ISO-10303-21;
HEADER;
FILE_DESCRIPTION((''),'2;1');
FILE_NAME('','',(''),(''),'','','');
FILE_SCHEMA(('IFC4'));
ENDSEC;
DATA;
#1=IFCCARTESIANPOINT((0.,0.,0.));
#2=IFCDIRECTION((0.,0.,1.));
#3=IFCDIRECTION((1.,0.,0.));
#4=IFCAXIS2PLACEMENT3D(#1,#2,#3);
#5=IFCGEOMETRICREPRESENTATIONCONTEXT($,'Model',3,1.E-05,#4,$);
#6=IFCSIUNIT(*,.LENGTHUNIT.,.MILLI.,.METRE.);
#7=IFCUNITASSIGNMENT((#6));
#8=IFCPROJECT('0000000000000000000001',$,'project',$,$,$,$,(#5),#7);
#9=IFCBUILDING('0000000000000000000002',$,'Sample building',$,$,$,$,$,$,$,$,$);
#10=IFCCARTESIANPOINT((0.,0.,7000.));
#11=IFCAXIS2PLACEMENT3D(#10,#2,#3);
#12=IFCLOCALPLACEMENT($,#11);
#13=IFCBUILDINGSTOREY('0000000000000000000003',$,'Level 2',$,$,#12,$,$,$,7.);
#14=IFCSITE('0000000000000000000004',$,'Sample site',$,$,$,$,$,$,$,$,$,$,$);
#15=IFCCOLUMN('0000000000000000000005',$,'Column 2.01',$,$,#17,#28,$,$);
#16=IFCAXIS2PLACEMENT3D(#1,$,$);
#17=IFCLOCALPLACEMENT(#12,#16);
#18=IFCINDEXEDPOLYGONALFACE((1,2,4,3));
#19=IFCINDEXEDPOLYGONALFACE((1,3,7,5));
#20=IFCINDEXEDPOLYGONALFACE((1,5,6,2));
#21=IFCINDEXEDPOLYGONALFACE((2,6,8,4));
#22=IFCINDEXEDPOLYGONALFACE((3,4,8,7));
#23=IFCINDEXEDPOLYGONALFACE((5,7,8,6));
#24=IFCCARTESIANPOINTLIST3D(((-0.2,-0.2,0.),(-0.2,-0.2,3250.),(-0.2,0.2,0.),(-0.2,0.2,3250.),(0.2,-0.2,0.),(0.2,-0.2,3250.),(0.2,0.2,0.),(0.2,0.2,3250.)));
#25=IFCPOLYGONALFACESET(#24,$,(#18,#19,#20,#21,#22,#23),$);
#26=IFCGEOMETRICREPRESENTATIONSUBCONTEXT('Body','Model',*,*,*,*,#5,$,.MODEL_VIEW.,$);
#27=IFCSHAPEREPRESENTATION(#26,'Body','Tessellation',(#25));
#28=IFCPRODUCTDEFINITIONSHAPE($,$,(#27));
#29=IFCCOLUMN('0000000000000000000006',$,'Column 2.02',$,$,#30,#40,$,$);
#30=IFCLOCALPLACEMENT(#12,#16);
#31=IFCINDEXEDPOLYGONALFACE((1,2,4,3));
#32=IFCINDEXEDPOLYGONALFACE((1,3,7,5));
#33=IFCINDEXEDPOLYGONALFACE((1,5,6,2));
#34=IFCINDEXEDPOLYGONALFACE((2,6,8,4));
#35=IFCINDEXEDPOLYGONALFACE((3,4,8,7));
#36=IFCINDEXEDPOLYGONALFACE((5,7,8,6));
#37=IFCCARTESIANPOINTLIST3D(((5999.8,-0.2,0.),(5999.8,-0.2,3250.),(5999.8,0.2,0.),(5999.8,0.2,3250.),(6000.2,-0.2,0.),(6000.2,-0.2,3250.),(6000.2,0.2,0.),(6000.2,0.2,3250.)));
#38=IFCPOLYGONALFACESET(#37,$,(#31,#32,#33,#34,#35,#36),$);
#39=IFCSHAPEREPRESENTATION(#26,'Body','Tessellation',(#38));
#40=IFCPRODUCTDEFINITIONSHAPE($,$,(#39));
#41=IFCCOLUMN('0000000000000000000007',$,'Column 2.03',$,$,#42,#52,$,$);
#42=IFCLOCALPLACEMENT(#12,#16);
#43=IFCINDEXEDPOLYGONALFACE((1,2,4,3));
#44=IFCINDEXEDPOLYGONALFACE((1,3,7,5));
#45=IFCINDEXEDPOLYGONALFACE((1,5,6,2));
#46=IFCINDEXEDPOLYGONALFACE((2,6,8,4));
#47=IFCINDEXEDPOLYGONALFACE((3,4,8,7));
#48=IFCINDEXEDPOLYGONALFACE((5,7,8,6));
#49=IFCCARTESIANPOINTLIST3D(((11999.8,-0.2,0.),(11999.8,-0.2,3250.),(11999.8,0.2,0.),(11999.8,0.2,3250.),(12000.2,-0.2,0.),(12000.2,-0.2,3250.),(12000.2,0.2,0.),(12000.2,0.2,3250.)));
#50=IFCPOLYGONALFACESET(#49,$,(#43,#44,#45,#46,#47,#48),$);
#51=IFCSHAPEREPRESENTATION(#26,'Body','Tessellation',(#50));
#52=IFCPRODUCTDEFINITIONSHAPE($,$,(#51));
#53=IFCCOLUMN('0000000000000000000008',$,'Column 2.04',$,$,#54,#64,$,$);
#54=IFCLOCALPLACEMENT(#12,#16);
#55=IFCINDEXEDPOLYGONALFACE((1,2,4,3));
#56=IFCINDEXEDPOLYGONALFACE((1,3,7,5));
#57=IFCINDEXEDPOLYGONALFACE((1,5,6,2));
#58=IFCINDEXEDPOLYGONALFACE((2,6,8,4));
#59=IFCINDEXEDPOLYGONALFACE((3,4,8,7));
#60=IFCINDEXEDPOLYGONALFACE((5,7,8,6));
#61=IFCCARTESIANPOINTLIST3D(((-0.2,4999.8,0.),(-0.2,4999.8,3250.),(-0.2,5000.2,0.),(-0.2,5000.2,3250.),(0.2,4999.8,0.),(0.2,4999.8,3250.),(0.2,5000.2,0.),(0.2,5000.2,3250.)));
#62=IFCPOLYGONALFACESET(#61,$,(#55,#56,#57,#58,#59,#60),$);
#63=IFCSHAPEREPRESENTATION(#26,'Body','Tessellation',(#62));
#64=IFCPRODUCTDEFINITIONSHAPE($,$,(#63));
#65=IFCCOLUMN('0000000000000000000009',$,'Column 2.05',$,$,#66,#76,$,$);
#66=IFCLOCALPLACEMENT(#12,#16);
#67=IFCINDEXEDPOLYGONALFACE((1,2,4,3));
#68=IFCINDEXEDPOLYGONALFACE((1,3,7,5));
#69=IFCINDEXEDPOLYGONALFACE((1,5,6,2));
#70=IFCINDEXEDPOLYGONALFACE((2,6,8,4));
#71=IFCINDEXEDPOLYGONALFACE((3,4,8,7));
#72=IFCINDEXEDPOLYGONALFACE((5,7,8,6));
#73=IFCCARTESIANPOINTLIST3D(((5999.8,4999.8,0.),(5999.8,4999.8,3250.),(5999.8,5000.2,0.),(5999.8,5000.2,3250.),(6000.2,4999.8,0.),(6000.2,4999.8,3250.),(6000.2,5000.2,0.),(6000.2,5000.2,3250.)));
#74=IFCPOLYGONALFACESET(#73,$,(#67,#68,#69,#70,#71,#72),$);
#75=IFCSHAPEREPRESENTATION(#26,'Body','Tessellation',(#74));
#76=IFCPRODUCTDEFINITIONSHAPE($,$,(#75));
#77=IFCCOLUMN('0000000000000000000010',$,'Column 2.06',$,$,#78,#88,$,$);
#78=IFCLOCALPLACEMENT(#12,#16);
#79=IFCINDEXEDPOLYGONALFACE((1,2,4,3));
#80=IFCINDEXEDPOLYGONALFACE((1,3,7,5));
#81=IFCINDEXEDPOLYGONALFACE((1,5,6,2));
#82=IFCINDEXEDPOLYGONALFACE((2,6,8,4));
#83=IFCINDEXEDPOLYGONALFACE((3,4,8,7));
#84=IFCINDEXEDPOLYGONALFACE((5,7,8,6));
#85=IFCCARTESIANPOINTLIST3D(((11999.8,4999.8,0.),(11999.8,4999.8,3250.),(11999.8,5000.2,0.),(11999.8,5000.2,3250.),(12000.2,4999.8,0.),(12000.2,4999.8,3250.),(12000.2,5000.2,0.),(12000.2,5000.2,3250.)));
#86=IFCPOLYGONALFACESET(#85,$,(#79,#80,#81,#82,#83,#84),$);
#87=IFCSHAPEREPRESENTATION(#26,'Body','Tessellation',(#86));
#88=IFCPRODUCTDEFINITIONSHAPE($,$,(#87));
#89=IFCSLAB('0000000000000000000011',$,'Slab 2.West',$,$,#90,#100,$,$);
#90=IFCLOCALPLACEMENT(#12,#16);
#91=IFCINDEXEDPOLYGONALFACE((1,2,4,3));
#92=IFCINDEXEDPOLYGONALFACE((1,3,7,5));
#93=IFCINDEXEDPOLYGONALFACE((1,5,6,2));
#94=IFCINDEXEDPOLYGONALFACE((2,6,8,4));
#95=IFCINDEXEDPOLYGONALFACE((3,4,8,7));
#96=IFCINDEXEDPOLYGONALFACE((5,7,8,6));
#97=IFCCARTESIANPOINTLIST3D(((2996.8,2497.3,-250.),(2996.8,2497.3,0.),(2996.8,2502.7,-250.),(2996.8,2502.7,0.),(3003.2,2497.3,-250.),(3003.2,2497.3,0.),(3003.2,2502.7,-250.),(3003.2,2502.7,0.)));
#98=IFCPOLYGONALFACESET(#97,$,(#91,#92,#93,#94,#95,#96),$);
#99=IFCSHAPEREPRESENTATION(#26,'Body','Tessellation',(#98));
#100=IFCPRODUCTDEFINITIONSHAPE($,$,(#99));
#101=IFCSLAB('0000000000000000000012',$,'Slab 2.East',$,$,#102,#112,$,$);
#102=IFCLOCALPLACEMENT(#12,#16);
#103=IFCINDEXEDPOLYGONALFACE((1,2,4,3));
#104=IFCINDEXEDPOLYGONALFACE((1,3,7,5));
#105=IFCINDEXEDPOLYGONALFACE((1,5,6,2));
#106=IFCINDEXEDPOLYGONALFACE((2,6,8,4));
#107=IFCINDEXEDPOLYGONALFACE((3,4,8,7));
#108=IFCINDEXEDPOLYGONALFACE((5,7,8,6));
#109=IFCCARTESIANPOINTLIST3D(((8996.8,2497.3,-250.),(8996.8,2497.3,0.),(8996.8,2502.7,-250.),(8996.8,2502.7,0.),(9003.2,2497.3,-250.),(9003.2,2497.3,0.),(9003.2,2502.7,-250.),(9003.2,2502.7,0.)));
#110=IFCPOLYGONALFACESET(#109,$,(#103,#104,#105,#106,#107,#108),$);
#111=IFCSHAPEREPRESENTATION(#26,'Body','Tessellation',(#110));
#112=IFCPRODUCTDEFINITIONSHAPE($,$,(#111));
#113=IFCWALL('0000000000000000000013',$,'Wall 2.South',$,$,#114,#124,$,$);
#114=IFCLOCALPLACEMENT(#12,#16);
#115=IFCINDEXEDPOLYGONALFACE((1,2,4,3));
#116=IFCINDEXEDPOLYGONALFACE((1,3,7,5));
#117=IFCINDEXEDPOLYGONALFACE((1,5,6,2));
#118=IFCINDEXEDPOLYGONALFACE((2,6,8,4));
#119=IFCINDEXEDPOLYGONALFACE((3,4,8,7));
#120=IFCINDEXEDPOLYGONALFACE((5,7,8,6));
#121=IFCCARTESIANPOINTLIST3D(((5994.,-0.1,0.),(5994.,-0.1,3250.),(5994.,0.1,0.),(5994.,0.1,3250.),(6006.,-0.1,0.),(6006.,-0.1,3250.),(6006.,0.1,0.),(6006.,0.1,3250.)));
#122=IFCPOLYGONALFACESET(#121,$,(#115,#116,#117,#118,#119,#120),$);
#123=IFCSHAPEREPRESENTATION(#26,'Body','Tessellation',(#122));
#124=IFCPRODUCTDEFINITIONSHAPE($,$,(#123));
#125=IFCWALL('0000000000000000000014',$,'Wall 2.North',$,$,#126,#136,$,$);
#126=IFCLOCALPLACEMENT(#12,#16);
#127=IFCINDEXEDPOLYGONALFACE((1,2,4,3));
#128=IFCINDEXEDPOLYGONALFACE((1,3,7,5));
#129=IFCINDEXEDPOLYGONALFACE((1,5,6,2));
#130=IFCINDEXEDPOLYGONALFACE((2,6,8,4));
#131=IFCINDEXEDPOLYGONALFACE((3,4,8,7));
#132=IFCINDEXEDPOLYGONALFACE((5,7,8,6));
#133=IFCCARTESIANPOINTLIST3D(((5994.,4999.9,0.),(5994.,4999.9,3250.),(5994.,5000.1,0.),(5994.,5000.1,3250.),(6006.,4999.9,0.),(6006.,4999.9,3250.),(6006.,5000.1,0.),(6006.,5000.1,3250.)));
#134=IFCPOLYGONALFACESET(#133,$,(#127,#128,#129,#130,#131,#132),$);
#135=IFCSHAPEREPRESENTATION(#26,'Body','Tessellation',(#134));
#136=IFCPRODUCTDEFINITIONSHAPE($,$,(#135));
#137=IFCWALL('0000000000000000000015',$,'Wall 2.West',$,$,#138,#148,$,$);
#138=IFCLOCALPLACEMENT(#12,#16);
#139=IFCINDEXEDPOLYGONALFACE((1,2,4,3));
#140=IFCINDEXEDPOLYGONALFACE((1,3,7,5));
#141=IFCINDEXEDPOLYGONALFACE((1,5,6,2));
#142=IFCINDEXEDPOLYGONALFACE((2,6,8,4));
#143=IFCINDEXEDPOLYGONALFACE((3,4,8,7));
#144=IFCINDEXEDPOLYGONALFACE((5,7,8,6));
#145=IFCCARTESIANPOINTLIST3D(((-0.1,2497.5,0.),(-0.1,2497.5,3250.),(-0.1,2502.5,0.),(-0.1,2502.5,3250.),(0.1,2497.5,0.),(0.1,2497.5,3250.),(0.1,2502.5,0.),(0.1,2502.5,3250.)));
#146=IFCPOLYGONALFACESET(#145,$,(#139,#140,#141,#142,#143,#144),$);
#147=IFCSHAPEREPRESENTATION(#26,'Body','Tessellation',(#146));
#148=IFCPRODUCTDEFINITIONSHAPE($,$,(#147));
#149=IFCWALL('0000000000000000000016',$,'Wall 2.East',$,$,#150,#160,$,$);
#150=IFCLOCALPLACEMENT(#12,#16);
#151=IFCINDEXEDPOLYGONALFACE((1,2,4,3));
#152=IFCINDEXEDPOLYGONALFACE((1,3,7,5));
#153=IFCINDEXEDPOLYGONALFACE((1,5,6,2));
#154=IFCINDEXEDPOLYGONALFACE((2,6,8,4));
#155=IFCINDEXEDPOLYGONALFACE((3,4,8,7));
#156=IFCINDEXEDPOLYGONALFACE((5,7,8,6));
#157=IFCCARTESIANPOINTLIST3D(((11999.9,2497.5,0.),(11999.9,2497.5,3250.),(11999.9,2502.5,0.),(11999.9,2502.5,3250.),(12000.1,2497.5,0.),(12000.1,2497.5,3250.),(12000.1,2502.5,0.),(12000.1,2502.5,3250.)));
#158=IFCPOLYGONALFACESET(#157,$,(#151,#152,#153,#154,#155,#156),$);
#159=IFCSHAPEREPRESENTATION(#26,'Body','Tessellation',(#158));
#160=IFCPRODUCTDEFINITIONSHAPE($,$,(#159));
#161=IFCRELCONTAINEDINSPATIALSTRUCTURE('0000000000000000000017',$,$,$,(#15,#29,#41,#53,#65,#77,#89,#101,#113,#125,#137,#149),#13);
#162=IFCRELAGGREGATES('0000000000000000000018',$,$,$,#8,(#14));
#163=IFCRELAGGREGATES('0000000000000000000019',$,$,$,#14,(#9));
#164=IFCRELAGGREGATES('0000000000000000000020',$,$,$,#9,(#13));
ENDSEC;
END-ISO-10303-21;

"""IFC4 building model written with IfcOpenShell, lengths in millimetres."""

from ifc_helpers import new_model, si_unit, frame, origin_with_axes, origin_2d, place, context, subcontext, project, spatial, rectangle, extrude, element, save


model = new_model("IFC4")

# Units and contexts
model_context = context("Model", 3, precision=1e-05, world=origin_with_axes())
body_context = subcontext(model_context, "Body", "Model", "MODEL_VIEW")
ifc_project = project(units=[si_unit("LENGTHUNIT", "METRE", prefix="MILLI")], contexts=[model_context])

# Site, building, storey
site = spatial("IfcSite", under=ifc_project, Name="Sample site")
building = spatial("IfcBuilding", under=site, Name="Sample building")
storey_placement = place(None, frame((0.0, 0.0, 7000.0), z_axis=(0.0, 0.0, 1.0), x_axis=(1.0, 0.0, 0.0)))
storey = spatial("IfcBuildingStorey", under=building, at=storey_placement, Name="Level 2", Elevation=7.0)

# Columns
for number, where, z_axis, x_axis, name in (
    (1, (0.0, 0.0, 0.0), (0.0, 0.0, 1.0), (1.0, 0.0, 0.0), "Column 2.01"),
    (2, (6000.0, 0.0, 0.0), (0.0, 0.0, 1.0), (1.0, 0.0, 0.0), "Column 2.02"),
    (3, (12000.0, 0.0, 0.0), (0.0, 0.0, 1.0), (1.0, 0.0, 0.0), "Column 2.03"),
    (4, (0.0, 5000.0, 0.0), (0.0, 0.0, 1.0), (1.0, 0.0, 0.0), "Column 2.04"),
    (5, (6000.0, 5000.0, 0.0), (0.0, 0.0, 1.0), (1.0, 0.0, 0.0), "Column 2.05"),
    (6, (12000.0, 5000.0, 0.0), (0.0, 0.0, 1.0), (1.0, 0.0, 0.0), "Column 2.06"),
):
    element("IfcColumn", number, at=place(storey_placement, frame(where, z_axis=z_axis, x_axis=x_axis)), inside=storey, Name=name, context=body_context, shape_type="SweptSolid", body=[
        extrude(rectangle(XDim=0.4, YDim=0.4, at=origin_2d()), origin_with_axes(), (0.0, 0.0, 1.0), 3250.0),
    ])

# Slabs
for number, where, z_axis, x_axis, name in (
    (7, (3000.0, 2500.0, -250.0), (0.0, 0.0, 1.0), (1.0, 0.0, 0.0), "Slab 2.West"),
    (8, (9000.0, 2500.0, -250.0), (0.0, 0.0, 1.0), (1.0, 0.0, 0.0), "Slab 2.East"),
):
    element("IfcSlab", number, at=place(storey_placement, frame(where, z_axis=z_axis, x_axis=x_axis)), inside=storey, Name=name, context=body_context, shape_type="SweptSolid", body=[
        extrude(rectangle(XDim=6.4, YDim=5.4, at=origin_2d()), origin_with_axes(), (0.0, 0.0, 1.0), 250.0),
    ])

# Walls
for number, where, z_axis, x_axis, name in (
    (9, (6000.0, 0.0, 0.0), (0.0, 0.0, 1.0), (1.0, 0.0, 0.0), "Wall 2.South"),
    (10, (6000.0, 5000.0, 0.0), (0.0, 0.0, 1.0), (1.0, 0.0, 0.0), "Wall 2.North"),
):
    element("IfcWall", number, at=place(storey_placement, frame(where, z_axis=z_axis, x_axis=x_axis)), inside=storey, Name=name, context=body_context, shape_type="SweptSolid", body=[
        extrude(rectangle(XDim=12.0, YDim=0.2, at=origin_2d()), origin_with_axes(), (0.0, 0.0, 1.0), 3250.0),
    ])
for number, where, z_axis, x_axis, name in (
    (11, (0.0, 2500.0, 0.0), (0.0, 0.0, 1.0), (0.0, 1.0, 0.0), "Wall 2.West"),
    (12, (12000.0, 2500.0, 0.0), (0.0, 0.0, 1.0), (0.0, 1.0, 0.0), "Wall 2.East"),
):
    element("IfcWall", number, at=place(storey_placement, frame(where, z_axis=z_axis, x_axis=x_axis)), inside=storey, Name=name, context=body_context, shape_type="SweptSolid", body=[
        extrude(rectangle(XDim=5.0, YDim=0.2, at=origin_2d()), origin_with_axes(), (0.0, 0.0, 1.0), 3250.0),
    ])

save(model, "model.ifc")
